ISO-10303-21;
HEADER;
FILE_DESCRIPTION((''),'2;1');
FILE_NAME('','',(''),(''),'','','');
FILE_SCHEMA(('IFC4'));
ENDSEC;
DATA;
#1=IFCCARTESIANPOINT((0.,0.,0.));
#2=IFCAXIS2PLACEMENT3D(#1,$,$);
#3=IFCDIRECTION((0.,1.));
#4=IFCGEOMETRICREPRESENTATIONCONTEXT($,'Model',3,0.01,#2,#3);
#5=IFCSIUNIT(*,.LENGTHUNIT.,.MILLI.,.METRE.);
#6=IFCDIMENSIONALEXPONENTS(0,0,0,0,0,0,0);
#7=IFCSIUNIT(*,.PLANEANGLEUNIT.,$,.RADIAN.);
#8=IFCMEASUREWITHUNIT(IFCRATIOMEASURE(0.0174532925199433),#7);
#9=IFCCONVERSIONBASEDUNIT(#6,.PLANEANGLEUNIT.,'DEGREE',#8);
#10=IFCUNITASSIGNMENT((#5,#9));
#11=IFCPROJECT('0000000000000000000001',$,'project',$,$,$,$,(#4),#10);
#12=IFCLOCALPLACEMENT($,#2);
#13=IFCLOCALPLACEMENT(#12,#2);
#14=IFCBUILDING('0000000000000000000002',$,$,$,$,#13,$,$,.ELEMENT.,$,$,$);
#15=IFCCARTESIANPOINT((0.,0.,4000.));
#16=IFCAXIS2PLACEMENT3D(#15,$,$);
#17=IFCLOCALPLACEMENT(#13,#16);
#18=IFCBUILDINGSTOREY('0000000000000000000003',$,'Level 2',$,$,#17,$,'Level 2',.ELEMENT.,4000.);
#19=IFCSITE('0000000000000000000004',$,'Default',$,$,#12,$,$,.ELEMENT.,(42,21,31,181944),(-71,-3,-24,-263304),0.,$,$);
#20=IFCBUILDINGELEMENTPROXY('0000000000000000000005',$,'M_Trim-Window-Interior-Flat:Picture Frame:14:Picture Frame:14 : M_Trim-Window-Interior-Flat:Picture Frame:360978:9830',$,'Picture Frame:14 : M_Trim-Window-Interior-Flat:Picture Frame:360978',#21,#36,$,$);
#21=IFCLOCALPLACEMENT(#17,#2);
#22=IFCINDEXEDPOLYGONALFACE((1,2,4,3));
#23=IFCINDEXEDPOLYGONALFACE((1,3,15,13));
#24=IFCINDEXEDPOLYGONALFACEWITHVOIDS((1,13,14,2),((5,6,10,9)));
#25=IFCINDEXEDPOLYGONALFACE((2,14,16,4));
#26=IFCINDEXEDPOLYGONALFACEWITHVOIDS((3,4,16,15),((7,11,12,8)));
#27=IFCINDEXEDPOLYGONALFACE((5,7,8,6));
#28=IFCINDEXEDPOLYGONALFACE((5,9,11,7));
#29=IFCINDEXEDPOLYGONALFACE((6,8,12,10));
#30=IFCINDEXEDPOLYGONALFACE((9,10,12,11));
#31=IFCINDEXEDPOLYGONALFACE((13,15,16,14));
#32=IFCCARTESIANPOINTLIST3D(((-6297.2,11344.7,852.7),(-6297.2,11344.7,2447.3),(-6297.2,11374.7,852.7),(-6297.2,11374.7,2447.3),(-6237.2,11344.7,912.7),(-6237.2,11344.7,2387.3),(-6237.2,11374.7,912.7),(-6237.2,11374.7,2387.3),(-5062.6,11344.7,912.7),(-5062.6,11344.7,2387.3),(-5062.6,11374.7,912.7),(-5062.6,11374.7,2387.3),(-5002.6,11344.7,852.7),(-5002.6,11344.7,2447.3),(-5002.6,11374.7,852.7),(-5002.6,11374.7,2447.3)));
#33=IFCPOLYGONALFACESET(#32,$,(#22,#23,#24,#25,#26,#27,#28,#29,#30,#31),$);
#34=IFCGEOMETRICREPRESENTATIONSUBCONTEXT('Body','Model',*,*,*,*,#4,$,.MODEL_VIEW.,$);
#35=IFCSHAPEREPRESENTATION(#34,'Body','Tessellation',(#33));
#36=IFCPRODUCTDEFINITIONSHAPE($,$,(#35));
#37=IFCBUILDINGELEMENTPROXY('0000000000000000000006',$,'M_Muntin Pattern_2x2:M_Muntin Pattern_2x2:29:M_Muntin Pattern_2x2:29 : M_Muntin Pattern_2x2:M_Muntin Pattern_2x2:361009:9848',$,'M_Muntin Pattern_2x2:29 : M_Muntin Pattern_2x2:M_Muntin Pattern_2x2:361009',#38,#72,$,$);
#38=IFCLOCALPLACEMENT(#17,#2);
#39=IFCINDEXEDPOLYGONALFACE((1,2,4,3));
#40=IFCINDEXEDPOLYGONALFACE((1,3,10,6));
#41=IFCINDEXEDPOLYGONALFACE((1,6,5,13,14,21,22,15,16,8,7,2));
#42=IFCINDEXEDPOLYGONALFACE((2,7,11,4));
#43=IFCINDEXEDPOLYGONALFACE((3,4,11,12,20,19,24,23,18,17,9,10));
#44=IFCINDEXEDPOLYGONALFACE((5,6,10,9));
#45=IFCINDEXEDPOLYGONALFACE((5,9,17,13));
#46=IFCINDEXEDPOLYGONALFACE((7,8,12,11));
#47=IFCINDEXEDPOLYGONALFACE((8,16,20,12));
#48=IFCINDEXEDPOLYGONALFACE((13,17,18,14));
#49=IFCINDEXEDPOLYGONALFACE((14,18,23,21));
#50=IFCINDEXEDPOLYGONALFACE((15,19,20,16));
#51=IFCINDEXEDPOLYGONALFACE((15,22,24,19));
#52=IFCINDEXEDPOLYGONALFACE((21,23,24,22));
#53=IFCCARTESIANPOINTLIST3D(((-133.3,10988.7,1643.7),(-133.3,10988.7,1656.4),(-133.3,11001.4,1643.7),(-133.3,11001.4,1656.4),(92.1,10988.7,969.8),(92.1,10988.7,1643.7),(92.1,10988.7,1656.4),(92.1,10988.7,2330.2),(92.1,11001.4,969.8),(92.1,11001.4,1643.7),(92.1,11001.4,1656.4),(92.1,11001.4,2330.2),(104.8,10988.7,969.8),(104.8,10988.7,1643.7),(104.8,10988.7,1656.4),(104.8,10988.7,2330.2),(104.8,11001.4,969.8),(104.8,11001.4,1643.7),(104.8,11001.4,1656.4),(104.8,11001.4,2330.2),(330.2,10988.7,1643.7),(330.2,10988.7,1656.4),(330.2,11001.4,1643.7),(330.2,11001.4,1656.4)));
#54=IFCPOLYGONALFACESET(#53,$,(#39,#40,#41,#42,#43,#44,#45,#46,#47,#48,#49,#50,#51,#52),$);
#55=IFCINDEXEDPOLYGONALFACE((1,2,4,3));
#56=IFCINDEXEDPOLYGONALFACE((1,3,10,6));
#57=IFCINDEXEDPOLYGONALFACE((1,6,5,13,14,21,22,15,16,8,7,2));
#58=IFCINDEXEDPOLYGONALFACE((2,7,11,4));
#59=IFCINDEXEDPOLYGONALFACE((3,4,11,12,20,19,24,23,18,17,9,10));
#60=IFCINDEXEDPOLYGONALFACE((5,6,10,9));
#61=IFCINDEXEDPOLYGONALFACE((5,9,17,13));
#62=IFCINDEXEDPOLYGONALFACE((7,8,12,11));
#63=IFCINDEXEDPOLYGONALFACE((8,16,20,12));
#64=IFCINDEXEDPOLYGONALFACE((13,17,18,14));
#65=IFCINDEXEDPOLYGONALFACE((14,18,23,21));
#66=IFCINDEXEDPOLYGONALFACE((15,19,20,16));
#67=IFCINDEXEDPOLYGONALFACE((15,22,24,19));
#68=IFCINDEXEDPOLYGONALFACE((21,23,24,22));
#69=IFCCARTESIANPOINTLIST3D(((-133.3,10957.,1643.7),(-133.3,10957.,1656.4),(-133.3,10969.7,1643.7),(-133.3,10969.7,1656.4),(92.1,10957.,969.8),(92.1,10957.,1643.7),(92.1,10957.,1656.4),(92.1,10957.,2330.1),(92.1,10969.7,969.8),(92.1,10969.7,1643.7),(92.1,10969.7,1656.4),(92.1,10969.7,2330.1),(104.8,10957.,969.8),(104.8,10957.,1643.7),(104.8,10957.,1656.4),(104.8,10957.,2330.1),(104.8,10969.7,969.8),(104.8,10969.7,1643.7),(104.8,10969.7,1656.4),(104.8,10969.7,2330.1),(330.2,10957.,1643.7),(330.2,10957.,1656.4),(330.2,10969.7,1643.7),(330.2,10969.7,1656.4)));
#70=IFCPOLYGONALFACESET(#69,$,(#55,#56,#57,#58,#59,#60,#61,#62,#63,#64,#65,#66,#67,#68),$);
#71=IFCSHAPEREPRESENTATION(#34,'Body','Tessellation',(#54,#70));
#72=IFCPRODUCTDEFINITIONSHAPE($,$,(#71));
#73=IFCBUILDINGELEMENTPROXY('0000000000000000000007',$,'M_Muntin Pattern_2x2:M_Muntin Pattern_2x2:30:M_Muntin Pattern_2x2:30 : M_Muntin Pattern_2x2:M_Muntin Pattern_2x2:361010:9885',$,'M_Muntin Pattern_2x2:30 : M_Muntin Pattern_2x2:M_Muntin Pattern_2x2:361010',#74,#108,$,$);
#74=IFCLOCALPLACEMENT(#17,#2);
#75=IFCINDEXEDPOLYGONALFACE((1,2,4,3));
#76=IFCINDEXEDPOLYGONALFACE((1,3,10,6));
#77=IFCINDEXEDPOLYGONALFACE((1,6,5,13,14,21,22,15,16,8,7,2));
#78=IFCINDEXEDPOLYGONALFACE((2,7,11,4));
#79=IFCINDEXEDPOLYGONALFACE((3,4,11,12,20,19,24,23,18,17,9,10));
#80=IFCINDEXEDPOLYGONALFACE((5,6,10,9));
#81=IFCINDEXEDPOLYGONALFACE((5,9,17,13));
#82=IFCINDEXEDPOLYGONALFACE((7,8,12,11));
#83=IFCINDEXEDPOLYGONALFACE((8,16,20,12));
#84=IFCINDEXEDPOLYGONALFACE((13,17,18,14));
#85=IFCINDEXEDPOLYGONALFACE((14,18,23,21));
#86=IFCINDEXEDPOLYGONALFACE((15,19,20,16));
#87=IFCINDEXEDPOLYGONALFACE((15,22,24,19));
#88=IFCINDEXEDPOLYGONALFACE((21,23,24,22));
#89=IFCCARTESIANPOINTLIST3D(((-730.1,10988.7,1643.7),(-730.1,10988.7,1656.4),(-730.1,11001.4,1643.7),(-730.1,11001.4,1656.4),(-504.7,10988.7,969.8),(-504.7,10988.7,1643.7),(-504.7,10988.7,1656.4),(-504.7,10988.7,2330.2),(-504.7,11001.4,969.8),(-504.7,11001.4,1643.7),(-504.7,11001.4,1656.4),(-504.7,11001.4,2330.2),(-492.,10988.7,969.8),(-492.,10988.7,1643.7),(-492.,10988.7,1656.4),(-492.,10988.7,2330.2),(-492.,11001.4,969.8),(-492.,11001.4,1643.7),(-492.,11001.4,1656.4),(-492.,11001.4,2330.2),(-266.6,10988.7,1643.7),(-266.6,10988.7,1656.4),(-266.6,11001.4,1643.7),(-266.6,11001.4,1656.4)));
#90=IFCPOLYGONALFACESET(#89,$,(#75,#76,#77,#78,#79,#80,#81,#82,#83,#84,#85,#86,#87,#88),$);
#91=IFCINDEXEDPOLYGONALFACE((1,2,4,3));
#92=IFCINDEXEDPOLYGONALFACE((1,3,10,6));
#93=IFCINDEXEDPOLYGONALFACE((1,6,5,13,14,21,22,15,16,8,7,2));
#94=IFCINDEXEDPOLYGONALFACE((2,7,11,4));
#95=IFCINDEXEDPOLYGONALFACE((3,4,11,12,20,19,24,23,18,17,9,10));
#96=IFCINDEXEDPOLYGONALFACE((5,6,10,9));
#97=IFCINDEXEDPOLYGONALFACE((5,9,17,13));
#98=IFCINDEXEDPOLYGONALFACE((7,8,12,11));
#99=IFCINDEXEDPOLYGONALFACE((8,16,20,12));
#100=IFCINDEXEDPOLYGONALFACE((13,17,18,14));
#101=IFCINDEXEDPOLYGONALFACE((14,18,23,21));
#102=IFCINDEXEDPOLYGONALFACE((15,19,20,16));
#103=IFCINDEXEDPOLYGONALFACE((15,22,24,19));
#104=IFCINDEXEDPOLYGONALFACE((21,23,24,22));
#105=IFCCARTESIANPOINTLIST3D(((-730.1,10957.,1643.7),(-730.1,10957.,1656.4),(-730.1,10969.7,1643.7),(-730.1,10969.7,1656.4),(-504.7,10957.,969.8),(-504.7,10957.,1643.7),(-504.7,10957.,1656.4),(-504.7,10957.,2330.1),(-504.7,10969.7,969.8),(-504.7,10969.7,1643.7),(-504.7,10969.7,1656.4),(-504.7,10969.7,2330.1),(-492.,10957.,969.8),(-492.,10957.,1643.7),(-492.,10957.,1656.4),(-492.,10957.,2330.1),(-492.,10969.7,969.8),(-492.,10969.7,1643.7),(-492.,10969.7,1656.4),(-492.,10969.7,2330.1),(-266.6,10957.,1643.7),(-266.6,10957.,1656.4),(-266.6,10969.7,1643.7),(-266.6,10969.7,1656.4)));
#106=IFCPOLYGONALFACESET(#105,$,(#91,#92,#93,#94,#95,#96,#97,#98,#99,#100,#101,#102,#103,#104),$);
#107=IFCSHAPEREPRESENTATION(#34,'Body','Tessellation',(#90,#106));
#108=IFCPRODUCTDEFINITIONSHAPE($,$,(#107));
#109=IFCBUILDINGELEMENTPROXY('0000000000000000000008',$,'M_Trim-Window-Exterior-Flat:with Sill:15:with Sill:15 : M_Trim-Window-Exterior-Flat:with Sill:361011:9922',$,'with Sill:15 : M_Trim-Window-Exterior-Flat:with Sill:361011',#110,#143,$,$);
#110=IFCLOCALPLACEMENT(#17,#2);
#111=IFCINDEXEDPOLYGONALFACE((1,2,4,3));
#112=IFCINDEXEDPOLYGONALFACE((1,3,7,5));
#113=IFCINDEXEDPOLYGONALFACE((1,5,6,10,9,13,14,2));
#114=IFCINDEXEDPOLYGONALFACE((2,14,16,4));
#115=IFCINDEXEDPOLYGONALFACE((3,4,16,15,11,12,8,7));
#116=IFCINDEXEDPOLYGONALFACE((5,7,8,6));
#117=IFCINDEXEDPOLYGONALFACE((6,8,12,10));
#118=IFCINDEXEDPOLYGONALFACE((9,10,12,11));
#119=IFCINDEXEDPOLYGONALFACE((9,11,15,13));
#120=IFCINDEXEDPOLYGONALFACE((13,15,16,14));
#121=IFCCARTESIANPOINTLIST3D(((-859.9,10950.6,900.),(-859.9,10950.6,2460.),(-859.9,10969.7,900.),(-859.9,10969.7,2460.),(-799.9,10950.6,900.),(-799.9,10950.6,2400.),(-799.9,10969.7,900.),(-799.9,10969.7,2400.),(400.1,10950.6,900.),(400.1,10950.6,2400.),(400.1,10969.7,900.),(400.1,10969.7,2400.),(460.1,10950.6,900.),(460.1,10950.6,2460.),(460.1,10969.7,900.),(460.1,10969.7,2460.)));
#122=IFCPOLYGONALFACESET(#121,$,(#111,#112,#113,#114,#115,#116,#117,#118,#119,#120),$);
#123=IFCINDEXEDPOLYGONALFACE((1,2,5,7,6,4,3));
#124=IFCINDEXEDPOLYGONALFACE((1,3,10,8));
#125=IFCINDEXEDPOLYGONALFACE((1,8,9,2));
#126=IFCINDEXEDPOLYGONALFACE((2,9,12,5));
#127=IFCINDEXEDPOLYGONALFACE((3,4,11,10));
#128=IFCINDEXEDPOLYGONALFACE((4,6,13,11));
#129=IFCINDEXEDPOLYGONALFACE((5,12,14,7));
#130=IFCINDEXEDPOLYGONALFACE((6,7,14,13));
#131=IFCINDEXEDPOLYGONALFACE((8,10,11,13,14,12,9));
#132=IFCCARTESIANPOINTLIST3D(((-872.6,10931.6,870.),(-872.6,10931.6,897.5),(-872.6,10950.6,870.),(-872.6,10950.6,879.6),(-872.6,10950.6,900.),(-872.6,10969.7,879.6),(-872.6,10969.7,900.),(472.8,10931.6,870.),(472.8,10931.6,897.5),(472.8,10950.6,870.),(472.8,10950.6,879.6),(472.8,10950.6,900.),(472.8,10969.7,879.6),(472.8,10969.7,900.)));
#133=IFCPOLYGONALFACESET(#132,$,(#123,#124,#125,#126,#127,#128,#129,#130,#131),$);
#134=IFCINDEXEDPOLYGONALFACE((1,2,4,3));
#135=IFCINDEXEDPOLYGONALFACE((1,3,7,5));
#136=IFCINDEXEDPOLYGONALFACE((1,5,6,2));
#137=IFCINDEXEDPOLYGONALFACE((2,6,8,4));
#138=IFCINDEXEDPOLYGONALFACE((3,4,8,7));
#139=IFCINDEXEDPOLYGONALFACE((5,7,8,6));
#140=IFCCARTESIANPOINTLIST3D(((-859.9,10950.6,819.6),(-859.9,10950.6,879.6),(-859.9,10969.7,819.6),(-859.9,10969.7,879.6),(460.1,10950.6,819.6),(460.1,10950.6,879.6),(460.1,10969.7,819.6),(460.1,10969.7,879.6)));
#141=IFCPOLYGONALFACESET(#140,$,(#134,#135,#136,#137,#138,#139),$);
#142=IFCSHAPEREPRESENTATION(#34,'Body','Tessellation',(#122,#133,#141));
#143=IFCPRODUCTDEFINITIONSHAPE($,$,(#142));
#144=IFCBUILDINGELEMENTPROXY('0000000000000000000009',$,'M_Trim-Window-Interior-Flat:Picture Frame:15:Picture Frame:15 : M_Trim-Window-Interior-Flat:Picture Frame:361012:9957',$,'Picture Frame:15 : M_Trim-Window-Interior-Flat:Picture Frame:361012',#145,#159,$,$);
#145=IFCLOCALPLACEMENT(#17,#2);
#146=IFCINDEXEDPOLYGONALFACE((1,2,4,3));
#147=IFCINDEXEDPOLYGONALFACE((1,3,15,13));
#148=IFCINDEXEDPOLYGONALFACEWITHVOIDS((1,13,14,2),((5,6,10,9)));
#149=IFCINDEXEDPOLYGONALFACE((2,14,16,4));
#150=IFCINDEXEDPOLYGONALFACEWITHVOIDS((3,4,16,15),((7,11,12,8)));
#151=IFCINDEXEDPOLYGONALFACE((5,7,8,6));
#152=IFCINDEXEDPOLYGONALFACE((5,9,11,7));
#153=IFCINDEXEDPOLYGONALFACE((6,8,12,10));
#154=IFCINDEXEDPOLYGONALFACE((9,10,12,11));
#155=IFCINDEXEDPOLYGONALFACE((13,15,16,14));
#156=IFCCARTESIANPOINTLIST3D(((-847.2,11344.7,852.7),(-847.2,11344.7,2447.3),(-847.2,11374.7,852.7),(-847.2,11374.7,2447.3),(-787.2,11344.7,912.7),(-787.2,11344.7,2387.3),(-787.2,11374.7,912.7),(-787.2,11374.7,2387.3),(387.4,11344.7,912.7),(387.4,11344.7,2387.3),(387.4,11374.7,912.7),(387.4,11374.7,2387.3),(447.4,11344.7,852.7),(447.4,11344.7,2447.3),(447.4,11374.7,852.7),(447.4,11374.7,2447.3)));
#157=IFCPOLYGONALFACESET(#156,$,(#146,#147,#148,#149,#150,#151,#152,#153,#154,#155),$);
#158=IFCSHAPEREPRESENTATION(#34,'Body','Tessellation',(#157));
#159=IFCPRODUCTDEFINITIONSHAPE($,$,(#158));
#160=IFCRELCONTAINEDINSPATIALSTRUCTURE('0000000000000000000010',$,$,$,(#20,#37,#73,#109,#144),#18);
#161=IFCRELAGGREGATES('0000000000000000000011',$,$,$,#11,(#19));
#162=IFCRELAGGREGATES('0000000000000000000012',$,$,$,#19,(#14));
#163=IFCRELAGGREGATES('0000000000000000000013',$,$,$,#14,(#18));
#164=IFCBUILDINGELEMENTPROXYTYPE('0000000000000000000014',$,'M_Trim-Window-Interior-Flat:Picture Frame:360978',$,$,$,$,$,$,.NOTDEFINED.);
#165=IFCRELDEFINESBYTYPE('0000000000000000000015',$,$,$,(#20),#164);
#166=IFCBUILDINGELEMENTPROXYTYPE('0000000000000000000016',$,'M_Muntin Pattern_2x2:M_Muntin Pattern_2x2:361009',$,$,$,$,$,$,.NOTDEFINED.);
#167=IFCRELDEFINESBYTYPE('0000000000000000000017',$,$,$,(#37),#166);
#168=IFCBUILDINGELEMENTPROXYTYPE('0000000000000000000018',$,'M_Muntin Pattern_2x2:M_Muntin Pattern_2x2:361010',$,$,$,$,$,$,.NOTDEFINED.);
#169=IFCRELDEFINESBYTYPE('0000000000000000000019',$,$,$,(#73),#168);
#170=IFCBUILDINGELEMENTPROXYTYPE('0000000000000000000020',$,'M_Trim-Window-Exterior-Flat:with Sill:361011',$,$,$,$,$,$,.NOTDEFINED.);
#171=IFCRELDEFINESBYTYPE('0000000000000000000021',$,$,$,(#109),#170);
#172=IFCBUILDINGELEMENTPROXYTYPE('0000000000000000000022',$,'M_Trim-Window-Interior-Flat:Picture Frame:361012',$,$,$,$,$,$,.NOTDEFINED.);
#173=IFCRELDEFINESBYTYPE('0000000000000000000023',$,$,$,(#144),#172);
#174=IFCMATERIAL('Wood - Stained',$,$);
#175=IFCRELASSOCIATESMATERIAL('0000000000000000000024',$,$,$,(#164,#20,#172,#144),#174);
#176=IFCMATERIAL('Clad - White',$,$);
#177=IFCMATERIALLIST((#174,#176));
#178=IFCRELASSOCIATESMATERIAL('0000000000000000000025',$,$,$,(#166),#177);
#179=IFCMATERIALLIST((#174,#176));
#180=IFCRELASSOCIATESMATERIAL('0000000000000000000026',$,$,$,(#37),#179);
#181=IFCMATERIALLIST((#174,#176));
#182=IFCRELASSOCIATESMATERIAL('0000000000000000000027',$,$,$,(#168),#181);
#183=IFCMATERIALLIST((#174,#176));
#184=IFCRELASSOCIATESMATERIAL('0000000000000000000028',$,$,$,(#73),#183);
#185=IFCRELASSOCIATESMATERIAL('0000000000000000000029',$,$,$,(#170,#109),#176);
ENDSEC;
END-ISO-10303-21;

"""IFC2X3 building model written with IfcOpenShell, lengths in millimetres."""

from ifc_helpers import new_model, entity, si_unit, converted_unit, direction, frame, origin, origin_2d_with_axis, place, context, subcontext, project, spatial, polyline, rectangle, outline, extrude, source, transform, mapped, material, material_list, type_object, type_shapes, element, save


model = new_model("IFC2X3")

# Units and contexts
model_context = context("Model", 3, precision=0.01, world=origin(), true_north=direction((0.0, 1.0)))
body_context = subcontext(model_context, "Body", "Model", "MODEL_VIEW")
ifc_project = project(units=[si_unit("LENGTHUNIT", "METRE", prefix="MILLI"), converted_unit("PLANEANGLEUNIT", "DEGREE", entity("IfcRatioMeasure", 0.0174532925199433), si_unit("PLANEANGLEUNIT", "RADIAN"), dimensions=[0, 0, 0, 0, 0, 0, 0])], contexts=[model_context])

# Site, building, storey
site_placement = place(None, origin())
site = spatial("IfcSite", under=ifc_project, at=site_placement, Name="Default", CompositionType="ELEMENT", RefLatitude=(42, 21, 31, 181944), RefLongitude=(-71, -3, -24, -263304), RefElevation=0.0)
building_placement = place(site_placement, origin())
building = spatial("IfcBuilding", under=site, at=building_placement, CompositionType="ELEMENT")
storey_placement = place(building_placement, frame((0.0, 0.0, 4000.0)))
storey = spatial("IfcBuildingStorey", under=building, at=storey_placement, Name="Level 2", LongName="Level 2", CompositionType="ELEMENT", Elevation=4000.0)

# Building element proxies
ifc_material_1 = material(Name="Wood - Stained")
ifc_material_2 = material(Name="Clad - White")
building_element_proxy_type_1 = type_object("IfcBuildingElementProxyType", Name="M_Trim-Window-Interior-Flat:Picture Frame:360978", PredefinedType="NOTDEFINED", material=ifc_material_1)
shared_shape_1 = source(origin(), body_context, "Body", "SweptSolid", [
    extrude(outline(polyline([(-797.3, -647.3), (797.3, -647.3), (797.3, 647.3), (-797.3, 647.3), (-797.3, -647.3)]), holes=[polyline([(737.3, 587.3), (737.3, -587.3), (-737.3, -587.3), (-737.3, 587.3), (737.3, 587.3)])]), frame((-5649.9, 11344.7, 5650.0), z_axis=(0.0, 1.0, 0.0), x_axis=(0.0, 0.0, -1.0)), (0.0, 0.0, 1.0), 30.0),
])
type_shapes(building_element_proxy_type_1, [shared_shape_1])
proxy_1_placement = place(storey_placement, frame((0.0, 0.0, -4000.0)))
element("IfcBuildingElementProxy", 1, at=proxy_1_placement, inside=storey, type_object=building_element_proxy_type_1, material=ifc_material_1, Name="M_Trim-Window-Interior-Flat:Picture Frame:14:Picture Frame:14 : M_Trim-Window-Interior-Flat:Picture Frame:360978:9830", ObjectType="Picture Frame:14 : M_Trim-Window-Interior-Flat:Picture Frame:360978", context=body_context, shape_type="MappedRepresentation", body=[
    mapped(shared_shape_1, transform((0.0, 0.0, 0.0), scale=1.0)),
])
ifc_material_list_1 = material_list([ifc_material_1, ifc_material_2])
ifc_material_list_2 = material_list([ifc_material_1, ifc_material_2])
building_element_proxy_type_2 = type_object("IfcBuildingElementProxyType", Name="M_Muntin Pattern_2x2:M_Muntin Pattern_2x2:361009", PredefinedType="NOTDEFINED", material=ifc_material_list_2)
shared_shape_2 = source(origin(), body_context, "Body", "SweptSolid", [
    extrude(outline(polyline([(-680.2, 6.4), (-680.2, -6.3), (-6.4, -6.3), (-6.4, -231.7), (6.3, -231.7), (6.3, -6.3), (680.2, -6.3), (680.2, 6.4), (6.3, 6.4), (6.3, 231.7), (-6.4, 231.7), (-6.4, 6.4), (-680.2, 6.4)])), frame((98.5, 10988.7, 5650.0), z_axis=(0.0, -1.0, 0.0), x_axis=(0.0, 0.0, -1.0)), (0.0, 0.0, -1.0), 12.7),
    extrude(outline(polyline([(-680.1, 6.4), (-680.1, -6.3), (-6.4, -6.3), (-6.4, -231.7), (6.3, -231.7), (6.3, -6.3), (680.2, -6.3), (680.2, 6.4), (6.3, 6.4), (6.3, 231.7), (-6.4, 231.7), (-6.4, 6.4), (-680.1, 6.4)])), frame((98.5, 10957.0, 5650.0), z_axis=(0.0, -1.0, 0.0), x_axis=(0.0, 0.0, -1.0)), (0.0, 0.0, -1.0), 12.7),
])
type_shapes(building_element_proxy_type_2, [shared_shape_2])
proxy_2_placement = place(storey_placement, frame((0.0, 0.0, -4000.0)))
element("IfcBuildingElementProxy", 2, at=proxy_2_placement, inside=storey, type_object=building_element_proxy_type_2, material=ifc_material_list_1, Name="M_Muntin Pattern_2x2:M_Muntin Pattern_2x2:29:M_Muntin Pattern_2x2:29 : M_Muntin Pattern_2x2:M_Muntin Pattern_2x2:361009:9848", ObjectType="M_Muntin Pattern_2x2:29 : M_Muntin Pattern_2x2:M_Muntin Pattern_2x2:361009", context=body_context, shape_type="MappedRepresentation", body=[
    mapped(shared_shape_2, transform((0.0, 0.0, 0.0), scale=1.0)),
])
ifc_material_list_3 = material_list([ifc_material_1, ifc_material_2])
ifc_material_list_4 = material_list([ifc_material_1, ifc_material_2])
building_element_proxy_type_3 = type_object("IfcBuildingElementProxyType", Name="M_Muntin Pattern_2x2:M_Muntin Pattern_2x2:361010", PredefinedType="NOTDEFINED", material=ifc_material_list_4)
shared_shape_3 = source(origin(), body_context, "Body", "SweptSolid", [
    extrude(outline(polyline([(-6.4, -680.1), (6.3, -680.1), (6.3, -6.4), (231.7, -6.4), (231.7, 6.3), (6.3, 6.3), (6.3, 680.2), (-6.4, 680.2), (-6.4, 6.3), (-231.7, 6.3), (-231.7, -6.4), (-6.4, -6.4), (-6.4, -680.1)])), frame((-498.4, 10988.7, 5650.0), z_axis=(0.0, 1.0, 0.0), x_axis=(1.0, 0.0, 0.0)), (0.0, 0.0, 1.0), 12.7),
    extrude(outline(polyline([(-6.4, -680.1), (6.3, -680.1), (6.3, -6.4), (231.7, -6.4), (231.7, 6.3), (6.3, 6.3), (6.3, 680.2), (-6.4, 680.2), (-6.4, 6.3), (-231.7, 6.3), (-231.7, -6.4), (-6.4, -6.4), (-6.4, -680.1)])), frame((-498.4, 10957.0, 5650.0), z_axis=(0.0, 1.0, 0.0), x_axis=(1.0, 0.0, 0.0)), (0.0, 0.0, 1.0), 12.7),
])
type_shapes(building_element_proxy_type_3, [shared_shape_3])
proxy_3_placement = place(storey_placement, frame((0.0, 0.0, -4000.0)))
element("IfcBuildingElementProxy", 3, at=proxy_3_placement, inside=storey, type_object=building_element_proxy_type_3, material=ifc_material_list_3, Name="M_Muntin Pattern_2x2:M_Muntin Pattern_2x2:30:M_Muntin Pattern_2x2:30 : M_Muntin Pattern_2x2:M_Muntin Pattern_2x2:361010:9885", ObjectType="M_Muntin Pattern_2x2:30 : M_Muntin Pattern_2x2:M_Muntin Pattern_2x2:361010", context=body_context, shape_type="MappedRepresentation", body=[
    mapped(shared_shape_3, transform((0.0, 0.0, 0.0), scale=1.0)),
])
building_element_proxy_type_4 = type_object("IfcBuildingElementProxyType", Name="M_Trim-Window-Exterior-Flat:with Sill:361011", PredefinedType="NOTDEFINED", material=ifc_material_2)
shared_shape_4 = source(origin(), body_context, "Body", "SweptSolid", [
    extrude(outline(polyline([(-765.0, -660.0), (795.0, -660.0), (795.0, 660.0), (-765.0, 660.0), (-765.0, 600.0), (735.0, 600.0), (735.0, -600.0), (-765.0, -600.0), (-765.0, -660.0)])), frame((-199.9, 10950.6, 5665.0), z_axis=(0.0, 1.0, 0.0), x_axis=(0.0, 0.0, 1.0)), (0.0, 0.0, 1.0), 19.1),
    extrude(outline(polyline([(-15.2, 0.0), (-15.2, -19.0), (12.3, -19.0), (14.8, 0.0), (14.8, 19.0), (-5.7, 19.0), (-5.7, 0.0), (-15.2, 0.0)])), frame((-872.6, 10950.6, 4885.2), z_axis=(-1.0, 0.0, 0.0), x_axis=(0.0, 0.0, 1.0)), (0.0, 0.0, -1.0), 1345.4),
    extrude(rectangle(XDim=19.1, YDim=1320.0, at=origin_2d_with_axis()), frame((-199.9, 10960.1, 4819.6), z_axis=(0.0, 0.0, 1.0), x_axis=(0.0, 1.0, 0.0)), (0.0, 0.0, 1.0), 60.0),
])
type_shapes(building_element_proxy_type_4, [shared_shape_4])
proxy_4_placement = place(storey_placement, frame((0.0, 0.0, -4000.0)))
element("IfcBuildingElementProxy", 4, at=proxy_4_placement, inside=storey, type_object=building_element_proxy_type_4, material=ifc_material_2, Name="M_Trim-Window-Exterior-Flat:with Sill:15:with Sill:15 : M_Trim-Window-Exterior-Flat:with Sill:361011:9922", ObjectType="with Sill:15 : M_Trim-Window-Exterior-Flat:with Sill:361011", context=body_context, shape_type="MappedRepresentation", body=[
    mapped(shared_shape_4, transform((0.0, 0.0, 0.0), scale=1.0)),
])
building_element_proxy_type_5 = type_object("IfcBuildingElementProxyType", Name="M_Trim-Window-Interior-Flat:Picture Frame:361012", PredefinedType="NOTDEFINED", material=ifc_material_1)
shared_shape_5 = source(origin(), body_context, "Body", "SweptSolid", [
    extrude(outline(polyline([(-797.3, -647.3), (797.3, -647.3), (797.3, 647.3), (-797.3, 647.3), (-797.3, -647.3)]), holes=[polyline([(737.3, 587.3), (737.3, -587.3), (-737.3, -587.3), (-737.3, 587.3), (737.3, 587.3)])]), frame((-199.9, 11344.7, 5650.0), z_axis=(0.0, 1.0, 0.0), x_axis=(0.0, 0.0, -1.0)), (0.0, 0.0, 1.0), 30.0),
])
type_shapes(building_element_proxy_type_5, [shared_shape_5])
proxy_5_placement = place(storey_placement, frame((0.0, 0.0, -4000.0)))
element("IfcBuildingElementProxy", 5, at=proxy_5_placement, inside=storey, type_object=building_element_proxy_type_5, material=ifc_material_1, Name="M_Trim-Window-Interior-Flat:Picture Frame:15:Picture Frame:15 : M_Trim-Window-Interior-Flat:Picture Frame:361012:9957", ObjectType="Picture Frame:15 : M_Trim-Window-Interior-Flat:Picture Frame:361012", context=body_context, shape_type="MappedRepresentation", body=[
    mapped(shared_shape_5, transform((0.0, 0.0, 0.0), scale=1.0)),
])

save(model, "model.ifc")
